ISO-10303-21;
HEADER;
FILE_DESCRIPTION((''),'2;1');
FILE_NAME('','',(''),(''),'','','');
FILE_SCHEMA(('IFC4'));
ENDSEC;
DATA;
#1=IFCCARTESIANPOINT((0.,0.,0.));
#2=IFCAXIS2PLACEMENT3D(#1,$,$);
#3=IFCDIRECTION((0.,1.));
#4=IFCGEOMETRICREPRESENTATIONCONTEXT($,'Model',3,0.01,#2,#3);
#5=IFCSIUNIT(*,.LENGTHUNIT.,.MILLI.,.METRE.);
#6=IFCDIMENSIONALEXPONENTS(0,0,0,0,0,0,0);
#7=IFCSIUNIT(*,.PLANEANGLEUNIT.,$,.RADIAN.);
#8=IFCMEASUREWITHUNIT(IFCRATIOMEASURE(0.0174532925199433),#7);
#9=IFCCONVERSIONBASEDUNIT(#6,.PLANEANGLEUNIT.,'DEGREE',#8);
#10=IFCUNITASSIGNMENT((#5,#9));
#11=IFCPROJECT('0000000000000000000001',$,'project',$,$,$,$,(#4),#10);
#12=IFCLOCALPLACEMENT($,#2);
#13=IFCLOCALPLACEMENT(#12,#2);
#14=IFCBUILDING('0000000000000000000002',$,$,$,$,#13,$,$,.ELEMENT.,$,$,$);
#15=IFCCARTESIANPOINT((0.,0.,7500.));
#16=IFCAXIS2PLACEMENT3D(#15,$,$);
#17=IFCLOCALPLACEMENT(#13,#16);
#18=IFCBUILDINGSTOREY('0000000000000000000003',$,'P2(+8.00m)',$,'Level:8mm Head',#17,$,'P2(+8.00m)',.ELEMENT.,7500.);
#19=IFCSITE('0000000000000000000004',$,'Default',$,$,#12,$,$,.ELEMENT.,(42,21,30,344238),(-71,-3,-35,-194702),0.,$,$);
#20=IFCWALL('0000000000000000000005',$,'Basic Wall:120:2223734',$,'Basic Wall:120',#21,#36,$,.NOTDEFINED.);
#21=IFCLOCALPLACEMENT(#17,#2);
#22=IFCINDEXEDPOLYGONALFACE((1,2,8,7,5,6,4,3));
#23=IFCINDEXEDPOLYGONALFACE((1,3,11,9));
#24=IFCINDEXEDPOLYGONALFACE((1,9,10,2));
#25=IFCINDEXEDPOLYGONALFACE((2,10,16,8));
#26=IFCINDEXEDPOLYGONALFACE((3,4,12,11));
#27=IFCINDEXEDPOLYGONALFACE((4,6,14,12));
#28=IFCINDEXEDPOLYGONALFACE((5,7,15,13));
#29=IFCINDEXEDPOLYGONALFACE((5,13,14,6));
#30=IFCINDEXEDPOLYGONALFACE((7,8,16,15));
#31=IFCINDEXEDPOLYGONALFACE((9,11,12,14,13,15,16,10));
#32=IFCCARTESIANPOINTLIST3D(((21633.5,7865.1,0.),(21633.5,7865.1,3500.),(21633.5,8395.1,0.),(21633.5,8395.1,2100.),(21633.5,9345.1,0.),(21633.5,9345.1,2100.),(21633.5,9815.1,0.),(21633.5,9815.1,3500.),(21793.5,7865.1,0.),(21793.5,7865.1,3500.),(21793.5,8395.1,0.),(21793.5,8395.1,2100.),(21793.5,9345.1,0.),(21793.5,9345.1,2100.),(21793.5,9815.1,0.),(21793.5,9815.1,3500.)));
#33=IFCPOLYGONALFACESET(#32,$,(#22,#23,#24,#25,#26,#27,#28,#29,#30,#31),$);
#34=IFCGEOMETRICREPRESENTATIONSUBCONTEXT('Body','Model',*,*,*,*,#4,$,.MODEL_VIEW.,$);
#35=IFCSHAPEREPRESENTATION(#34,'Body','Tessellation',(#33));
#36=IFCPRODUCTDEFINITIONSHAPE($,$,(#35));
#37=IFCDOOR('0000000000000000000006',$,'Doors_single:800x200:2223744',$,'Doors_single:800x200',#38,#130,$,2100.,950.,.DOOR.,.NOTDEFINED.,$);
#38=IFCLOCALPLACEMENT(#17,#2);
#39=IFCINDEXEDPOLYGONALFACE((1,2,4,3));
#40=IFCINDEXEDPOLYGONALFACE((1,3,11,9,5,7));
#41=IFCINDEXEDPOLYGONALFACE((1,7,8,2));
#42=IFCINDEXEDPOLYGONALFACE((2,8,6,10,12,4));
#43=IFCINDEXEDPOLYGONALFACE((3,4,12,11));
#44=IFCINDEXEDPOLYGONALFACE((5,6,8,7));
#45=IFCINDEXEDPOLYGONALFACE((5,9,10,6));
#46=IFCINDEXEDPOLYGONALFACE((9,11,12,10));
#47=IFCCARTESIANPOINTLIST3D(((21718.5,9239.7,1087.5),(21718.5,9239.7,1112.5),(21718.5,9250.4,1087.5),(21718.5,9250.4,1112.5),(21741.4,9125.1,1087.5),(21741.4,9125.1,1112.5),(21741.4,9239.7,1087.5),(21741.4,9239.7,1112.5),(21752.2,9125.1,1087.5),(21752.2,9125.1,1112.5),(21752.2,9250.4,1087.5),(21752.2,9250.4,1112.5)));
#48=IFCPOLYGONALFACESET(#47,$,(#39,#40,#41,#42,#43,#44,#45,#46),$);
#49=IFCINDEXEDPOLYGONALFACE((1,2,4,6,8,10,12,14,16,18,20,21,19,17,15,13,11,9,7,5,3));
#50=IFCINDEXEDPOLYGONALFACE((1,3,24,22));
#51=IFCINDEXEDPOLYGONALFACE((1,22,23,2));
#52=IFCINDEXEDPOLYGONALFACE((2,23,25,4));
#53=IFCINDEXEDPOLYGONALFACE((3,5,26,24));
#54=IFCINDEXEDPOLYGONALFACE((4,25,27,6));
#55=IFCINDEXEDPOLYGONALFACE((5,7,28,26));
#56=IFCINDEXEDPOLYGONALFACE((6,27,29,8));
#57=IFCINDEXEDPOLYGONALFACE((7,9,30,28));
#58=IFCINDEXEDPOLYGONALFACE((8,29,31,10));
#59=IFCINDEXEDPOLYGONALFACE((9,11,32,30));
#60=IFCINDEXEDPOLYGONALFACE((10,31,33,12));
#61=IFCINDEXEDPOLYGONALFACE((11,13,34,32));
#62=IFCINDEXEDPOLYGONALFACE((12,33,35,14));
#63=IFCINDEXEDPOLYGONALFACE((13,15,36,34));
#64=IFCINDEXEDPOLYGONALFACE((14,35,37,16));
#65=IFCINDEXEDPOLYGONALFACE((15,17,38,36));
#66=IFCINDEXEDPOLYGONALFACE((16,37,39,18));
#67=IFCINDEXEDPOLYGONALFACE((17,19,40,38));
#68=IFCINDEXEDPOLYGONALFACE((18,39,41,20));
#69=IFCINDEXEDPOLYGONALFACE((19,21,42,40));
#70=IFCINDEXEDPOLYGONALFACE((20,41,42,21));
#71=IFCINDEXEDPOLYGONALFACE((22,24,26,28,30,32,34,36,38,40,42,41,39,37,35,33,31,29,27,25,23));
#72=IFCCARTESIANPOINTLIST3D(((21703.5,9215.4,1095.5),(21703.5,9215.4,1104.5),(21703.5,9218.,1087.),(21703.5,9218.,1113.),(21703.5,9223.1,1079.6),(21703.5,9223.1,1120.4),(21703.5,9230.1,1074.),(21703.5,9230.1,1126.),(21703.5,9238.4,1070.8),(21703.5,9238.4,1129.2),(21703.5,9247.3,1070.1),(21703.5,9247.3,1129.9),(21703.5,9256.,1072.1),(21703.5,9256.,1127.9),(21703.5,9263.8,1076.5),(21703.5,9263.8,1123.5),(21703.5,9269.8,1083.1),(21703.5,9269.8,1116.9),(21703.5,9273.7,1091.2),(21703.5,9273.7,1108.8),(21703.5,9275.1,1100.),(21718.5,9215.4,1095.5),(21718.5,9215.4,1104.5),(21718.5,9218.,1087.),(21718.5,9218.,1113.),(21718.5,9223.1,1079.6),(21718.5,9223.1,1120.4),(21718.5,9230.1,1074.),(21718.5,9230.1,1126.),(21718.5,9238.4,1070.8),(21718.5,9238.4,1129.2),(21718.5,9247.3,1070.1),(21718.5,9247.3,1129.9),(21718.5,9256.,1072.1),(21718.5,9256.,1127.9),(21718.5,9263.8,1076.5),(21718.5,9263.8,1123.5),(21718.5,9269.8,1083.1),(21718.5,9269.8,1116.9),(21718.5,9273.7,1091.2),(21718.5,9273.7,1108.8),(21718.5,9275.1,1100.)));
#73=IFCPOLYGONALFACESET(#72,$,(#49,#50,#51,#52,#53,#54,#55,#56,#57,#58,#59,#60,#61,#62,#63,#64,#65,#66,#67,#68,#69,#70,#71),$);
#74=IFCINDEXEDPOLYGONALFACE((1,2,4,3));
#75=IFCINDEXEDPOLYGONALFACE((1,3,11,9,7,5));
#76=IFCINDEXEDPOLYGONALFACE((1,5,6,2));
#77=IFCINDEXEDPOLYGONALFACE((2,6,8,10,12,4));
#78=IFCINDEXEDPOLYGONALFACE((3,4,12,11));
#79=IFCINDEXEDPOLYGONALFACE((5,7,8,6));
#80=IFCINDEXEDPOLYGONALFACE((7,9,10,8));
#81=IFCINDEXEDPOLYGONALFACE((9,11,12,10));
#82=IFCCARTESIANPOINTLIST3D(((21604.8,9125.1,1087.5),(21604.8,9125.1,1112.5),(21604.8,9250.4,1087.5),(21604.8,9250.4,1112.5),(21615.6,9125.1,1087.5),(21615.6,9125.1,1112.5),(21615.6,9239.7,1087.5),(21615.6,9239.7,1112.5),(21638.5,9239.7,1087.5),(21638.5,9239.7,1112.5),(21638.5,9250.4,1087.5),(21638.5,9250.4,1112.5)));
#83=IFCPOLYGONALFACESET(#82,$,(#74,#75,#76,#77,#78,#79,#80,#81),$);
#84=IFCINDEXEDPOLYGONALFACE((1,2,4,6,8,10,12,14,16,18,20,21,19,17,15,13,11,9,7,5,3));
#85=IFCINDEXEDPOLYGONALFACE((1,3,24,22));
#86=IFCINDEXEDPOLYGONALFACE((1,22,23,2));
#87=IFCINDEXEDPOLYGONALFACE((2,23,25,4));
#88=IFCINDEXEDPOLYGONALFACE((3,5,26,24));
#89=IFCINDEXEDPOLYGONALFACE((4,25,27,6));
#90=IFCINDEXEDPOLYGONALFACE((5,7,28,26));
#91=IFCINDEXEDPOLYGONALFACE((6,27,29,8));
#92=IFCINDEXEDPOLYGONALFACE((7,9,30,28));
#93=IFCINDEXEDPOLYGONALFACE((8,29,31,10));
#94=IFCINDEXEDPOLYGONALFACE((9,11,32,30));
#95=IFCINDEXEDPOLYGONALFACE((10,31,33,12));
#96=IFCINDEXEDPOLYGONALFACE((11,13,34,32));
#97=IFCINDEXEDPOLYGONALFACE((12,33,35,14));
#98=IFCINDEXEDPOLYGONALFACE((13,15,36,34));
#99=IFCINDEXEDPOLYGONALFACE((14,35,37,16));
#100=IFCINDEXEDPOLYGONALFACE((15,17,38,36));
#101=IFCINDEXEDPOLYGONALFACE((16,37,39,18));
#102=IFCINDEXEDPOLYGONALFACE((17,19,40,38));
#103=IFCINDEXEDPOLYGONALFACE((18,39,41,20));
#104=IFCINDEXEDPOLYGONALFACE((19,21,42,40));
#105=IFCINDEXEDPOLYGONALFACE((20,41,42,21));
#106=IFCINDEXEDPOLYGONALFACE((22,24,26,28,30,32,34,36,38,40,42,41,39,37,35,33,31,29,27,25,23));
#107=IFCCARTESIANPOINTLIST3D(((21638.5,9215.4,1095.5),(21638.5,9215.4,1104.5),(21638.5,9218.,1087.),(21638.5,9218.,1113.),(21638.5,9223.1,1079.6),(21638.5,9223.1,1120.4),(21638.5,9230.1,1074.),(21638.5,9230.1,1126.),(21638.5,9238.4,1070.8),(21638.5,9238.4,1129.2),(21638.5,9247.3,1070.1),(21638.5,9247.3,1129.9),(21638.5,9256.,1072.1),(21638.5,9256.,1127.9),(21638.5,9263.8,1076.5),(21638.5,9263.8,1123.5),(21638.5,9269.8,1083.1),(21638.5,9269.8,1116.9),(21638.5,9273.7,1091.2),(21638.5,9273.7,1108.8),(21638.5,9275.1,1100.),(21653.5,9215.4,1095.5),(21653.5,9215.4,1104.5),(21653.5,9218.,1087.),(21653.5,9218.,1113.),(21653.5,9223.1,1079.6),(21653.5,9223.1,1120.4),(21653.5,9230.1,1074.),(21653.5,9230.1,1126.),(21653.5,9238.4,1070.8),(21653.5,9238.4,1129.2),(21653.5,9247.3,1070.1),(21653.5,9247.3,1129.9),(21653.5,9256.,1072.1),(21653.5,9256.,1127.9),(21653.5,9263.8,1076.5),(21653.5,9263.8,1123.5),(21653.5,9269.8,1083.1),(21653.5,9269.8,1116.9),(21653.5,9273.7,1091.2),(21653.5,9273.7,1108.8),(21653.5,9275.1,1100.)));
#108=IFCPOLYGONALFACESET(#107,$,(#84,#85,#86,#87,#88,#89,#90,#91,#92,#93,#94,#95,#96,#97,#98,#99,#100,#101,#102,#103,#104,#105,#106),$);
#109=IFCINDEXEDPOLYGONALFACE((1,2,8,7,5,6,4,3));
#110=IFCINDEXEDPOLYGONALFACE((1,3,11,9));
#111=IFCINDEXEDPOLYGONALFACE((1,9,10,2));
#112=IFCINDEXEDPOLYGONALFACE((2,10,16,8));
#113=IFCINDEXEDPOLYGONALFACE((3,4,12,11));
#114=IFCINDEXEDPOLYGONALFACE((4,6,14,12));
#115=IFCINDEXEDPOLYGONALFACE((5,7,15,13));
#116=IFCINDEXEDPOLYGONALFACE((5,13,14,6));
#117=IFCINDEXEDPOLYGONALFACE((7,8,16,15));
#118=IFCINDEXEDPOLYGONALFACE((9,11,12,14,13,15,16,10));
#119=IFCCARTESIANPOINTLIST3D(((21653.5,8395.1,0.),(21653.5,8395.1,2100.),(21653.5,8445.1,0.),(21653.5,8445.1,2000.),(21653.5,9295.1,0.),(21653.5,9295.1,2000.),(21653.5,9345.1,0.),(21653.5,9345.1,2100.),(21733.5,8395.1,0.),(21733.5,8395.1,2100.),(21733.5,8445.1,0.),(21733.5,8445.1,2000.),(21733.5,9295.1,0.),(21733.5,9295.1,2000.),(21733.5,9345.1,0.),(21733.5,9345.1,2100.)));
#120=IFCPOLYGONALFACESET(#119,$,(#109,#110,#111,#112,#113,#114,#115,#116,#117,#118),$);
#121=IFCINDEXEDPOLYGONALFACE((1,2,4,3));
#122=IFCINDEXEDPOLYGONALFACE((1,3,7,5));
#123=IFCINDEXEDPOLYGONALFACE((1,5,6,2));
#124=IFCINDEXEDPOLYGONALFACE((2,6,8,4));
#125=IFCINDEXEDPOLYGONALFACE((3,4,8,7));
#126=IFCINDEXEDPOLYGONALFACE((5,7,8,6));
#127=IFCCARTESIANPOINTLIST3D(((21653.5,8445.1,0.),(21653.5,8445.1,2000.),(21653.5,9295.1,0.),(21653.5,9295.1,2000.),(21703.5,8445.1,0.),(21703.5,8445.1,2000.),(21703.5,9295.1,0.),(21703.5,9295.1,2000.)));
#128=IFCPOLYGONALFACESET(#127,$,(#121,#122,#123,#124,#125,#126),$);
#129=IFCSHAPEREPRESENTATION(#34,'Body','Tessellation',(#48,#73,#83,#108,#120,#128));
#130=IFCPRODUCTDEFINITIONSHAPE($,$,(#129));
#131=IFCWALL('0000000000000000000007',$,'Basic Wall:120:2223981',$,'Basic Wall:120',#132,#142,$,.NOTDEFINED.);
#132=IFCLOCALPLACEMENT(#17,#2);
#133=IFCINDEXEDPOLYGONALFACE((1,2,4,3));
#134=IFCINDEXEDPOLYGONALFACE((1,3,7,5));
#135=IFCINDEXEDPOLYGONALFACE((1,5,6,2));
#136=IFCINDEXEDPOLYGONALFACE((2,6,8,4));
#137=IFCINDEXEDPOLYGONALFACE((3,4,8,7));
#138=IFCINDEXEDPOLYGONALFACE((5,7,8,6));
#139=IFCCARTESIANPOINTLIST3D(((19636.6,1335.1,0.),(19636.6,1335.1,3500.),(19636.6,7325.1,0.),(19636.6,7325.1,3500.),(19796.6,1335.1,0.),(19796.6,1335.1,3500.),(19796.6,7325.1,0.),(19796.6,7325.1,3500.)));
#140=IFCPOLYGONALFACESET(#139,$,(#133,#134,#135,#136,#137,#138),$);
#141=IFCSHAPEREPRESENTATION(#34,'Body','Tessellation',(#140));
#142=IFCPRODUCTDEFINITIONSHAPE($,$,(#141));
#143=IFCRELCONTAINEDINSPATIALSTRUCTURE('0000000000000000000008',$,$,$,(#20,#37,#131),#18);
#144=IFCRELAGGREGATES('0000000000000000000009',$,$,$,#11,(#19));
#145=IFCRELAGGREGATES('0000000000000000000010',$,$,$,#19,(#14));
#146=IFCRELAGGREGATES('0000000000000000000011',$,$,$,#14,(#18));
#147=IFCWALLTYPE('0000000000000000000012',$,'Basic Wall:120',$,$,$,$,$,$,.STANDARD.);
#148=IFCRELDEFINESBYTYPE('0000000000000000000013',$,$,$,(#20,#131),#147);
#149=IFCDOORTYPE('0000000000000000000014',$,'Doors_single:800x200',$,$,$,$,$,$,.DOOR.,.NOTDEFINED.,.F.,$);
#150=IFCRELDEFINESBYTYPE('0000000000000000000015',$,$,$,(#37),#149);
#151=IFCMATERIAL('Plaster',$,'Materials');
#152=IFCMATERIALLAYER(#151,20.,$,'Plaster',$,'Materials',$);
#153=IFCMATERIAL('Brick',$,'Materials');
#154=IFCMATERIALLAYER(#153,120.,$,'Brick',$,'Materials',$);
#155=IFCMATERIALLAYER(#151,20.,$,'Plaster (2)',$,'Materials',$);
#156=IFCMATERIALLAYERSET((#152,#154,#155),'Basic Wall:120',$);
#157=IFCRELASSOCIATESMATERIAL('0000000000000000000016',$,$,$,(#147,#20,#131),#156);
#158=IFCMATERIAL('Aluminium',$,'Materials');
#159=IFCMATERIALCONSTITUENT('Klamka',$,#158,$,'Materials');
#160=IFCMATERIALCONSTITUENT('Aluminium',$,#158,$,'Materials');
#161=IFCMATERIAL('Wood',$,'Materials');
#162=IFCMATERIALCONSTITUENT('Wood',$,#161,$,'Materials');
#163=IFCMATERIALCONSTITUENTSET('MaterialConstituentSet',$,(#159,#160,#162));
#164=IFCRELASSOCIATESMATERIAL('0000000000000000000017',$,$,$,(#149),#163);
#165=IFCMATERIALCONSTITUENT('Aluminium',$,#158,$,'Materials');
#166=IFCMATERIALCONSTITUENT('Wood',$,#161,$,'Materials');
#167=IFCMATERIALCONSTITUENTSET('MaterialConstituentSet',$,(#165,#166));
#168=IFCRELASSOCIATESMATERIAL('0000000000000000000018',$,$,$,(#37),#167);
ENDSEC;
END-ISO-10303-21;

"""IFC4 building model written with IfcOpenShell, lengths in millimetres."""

from ifc_helpers import new_model, entity, si_unit, converted_unit, direction, frame, frame_2d, origin, origin_2d_with_axis, place, context, subcontext, project, spatial, polyline, rectangle, circle, outline, extrude, source, transform, mapped, material, layer, layer_set, layer_usage, constituent, constituent_set, type_object, type_shapes, element, fill, save


model = new_model("IFC4")

# Units and contexts
model_context = context("Model", 3, precision=0.01, world=origin(), true_north=direction((0.0, 1.0)))
body_context = subcontext(model_context, "Body", "Model", "MODEL_VIEW")
ifc_project = project(units=[si_unit("LENGTHUNIT", "METRE", prefix="MILLI"), converted_unit("PLANEANGLEUNIT", "DEGREE", entity("IfcRatioMeasure", 0.0174532925199433), si_unit("PLANEANGLEUNIT", "RADIAN"), dimensions=[0, 0, 0, 0, 0, 0, 0])], contexts=[model_context])

# Site, building, storey
site_placement = place(None, origin())
site = spatial("IfcSite", under=ifc_project, at=site_placement, Name="Default", CompositionType="ELEMENT", RefLatitude=(42, 21, 30, 344238), RefLongitude=(-71, -3, -35, -194702), RefElevation=0.0)
building_placement = place(site_placement, origin())
building = spatial("IfcBuilding", under=site, at=building_placement, CompositionType="ELEMENT")
storey_placement = place(building_placement, frame((0.0, 0.0, 7500.0)))
storey = spatial("IfcBuildingStorey", under=building, at=storey_placement, Name="P2(+8.00m)", ObjectType="Level:8mm Head", LongName="P2(+8.00m)", CompositionType="ELEMENT", Elevation=7500.0)

# Shared definitions
ifc_material_1 = material(Name="Brick", Category="Materials")
ifc_material_2 = material(Name="Plaster", Category="Materials")

# Shared definitions
ifc_layer_1 = layer(ifc_material_2, 20.0, Name="Plaster", Category="Materials")
ifc_layer_2 = layer(ifc_material_1, 120.0, Name="Brick", Category="Materials")
ifc_layer_3 = layer(ifc_material_2, 20.0, Name="Plaster (2)", Category="Materials")
ifc_layer_set_1 = layer_set([ifc_layer_1, ifc_layer_2, ifc_layer_3], Name="Basic Wall:120")
wall_type_1 = type_object("IfcWallType", Name="Basic Wall:120", PredefinedType="STANDARD", material=ifc_layer_set_1)

# Wall, opening, door
ifc_material_3 = material(Name="Aluminium", Category="Materials")
ifc_material_4 = material(Name="Wood", Category="Materials")
ifc_layer_usage_1 = layer_usage(ifc_layer_set_1, "AXIS2", "NEGATIVE", 80.0)
wall_1_placement = place(storey_placement, frame((21713.5, 9815.1, 0.0), z_axis=(0.0, 0.0, 1.0), x_axis=(0.0, -1.0, 0.0)))
wall_1 = element("IfcWall", 1, at=wall_1_placement, inside=storey, type_object=wall_type_1, material=ifc_layer_usage_1, Name="Basic Wall:120:2223734", ObjectType="Basic Wall:120", PredefinedType="NOTDEFINED", context=body_context, shape_type="SweptSolid", body=[
    extrude(rectangle(XDim=1950.0, YDim=160.0, at=frame_2d((975.0, 0.0), x_axis=(-1.0, 0.0))), origin(), (0.0, 0.0, 1.0), 3500.0),
])
opening_1_placement = place(wall_1_placement, frame((1420.0, 80.0, 0.0)))
opening_1 = element("IfcOpeningElement", 2, at=opening_1_placement, cuts=wall_1, PredefinedType="OPENING", context=body_context, shape_type="SweptSolid", body=[
    extrude(rectangle(XDim=2100.0, YDim=950.0, at=frame_2d((1050.0, 475.0), x_axis=(1.0, 0.0))), frame((0.0, 0.0, 0.0), z_axis=(0.0, -1.0, 0.0), x_axis=(0.0, 0.0, 1.0)), (0.0, 0.0, 1.0), 160.0),
])
ifc_constituent_1 = constituent(ifc_material_3, Name="Aluminium", Category="Materials")
ifc_constituent_2 = constituent(ifc_material_4, Name="Wood", Category="Materials")
ifc_constituent_set_1 = constituent_set(constituents=[ifc_constituent_1, ifc_constituent_2], Name="MaterialConstituentSet")
ifc_constituent_3 = constituent(ifc_material_3, Name="Klamka", Category="Materials")
ifc_constituent_4 = constituent(ifc_material_3, Name="Aluminium", Category="Materials")
ifc_constituent_5 = constituent(ifc_material_4, Name="Wood", Category="Materials")
ifc_constituent_set_2 = constituent_set(constituents=[ifc_constituent_3, ifc_constituent_4, ifc_constituent_5], Name="MaterialConstituentSet")
door_type_1 = type_object("IfcDoorType", Name="Doors_single:800x200", OperationType="NOTDEFINED", ParameterTakesPrecedence=False, PredefinedType="DOOR", material=ifc_constituent_set_2)
shared_shape_1 = source(origin(), body_context, "Body", "SweptSolid", [
    extrude(outline(polyline([(-45.4, -18.9), (-34.6, -18.9), (-34.6, 4.0), (80.0, 4.0), (80.0, 14.8), (-45.4, 14.8), (-45.4, -18.9)])), frame((810.0, 56.1, 1087.5), z_axis=(0.0, 0.0, 1.0), x_axis=(-1.0, 0.0, 0.0)), (0.0, 0.0, 1.0), 25.0),
    extrude(circle(Radius=30.0, at=origin_2d_with_axis()), frame((850.0, 75.0, 1100.0), z_axis=(0.0, 1.0, 0.0), x_axis=(1.0, 0.0, 0.0)), (0.0, 0.0, 1.0), 15.0),
    extrude(outline(polyline([(-18.9, -45.4), (14.8, -45.4), (14.8, 80.0), (4.0, 80.0), (4.0, -34.6), (-18.9, -34.6), (-18.9, -45.4)])), frame((810.0, 173.9, 1087.5), z_axis=(0.0, 0.0, 1.0), x_axis=(0.0, 1.0, 0.0)), (0.0, 0.0, 1.0), 25.0),
    extrude(circle(Radius=30.0, at=origin_2d_with_axis()), frame((850.0, 140.0, 1100.0), z_axis=(0.0, 1.0, 0.0), x_axis=(1.0, 0.0, 0.0)), (0.0, 0.0, 1.0), 15.0),
    extrude(outline(polyline([(-475.0, -1025.0), (-425.0, -1025.0), (-425.0, 975.0), (425.0, 975.0), (425.0, -1025.0), (475.0, -1025.0), (475.0, 1075.0), (-475.0, 1075.0), (-475.0, -1025.0)])), frame((475.0, 60.0, 1025.0), z_axis=(0.0, 1.0, 0.0), x_axis=(-1.0, 0.0, 0.0)), (0.0, 0.0, 1.0), 80.0),
    extrude(rectangle(XDim=850.0, YDim=50.0, at=origin_2d_with_axis()), frame((475.0, 115.0, 0.0), z_axis=(0.0, 0.0, 1.0), x_axis=(-1.0, 0.0, 0.0)), (0.0, 0.0, 1.0), 2000.0),
])
type_shapes(door_type_1, [shared_shape_1])
door_1_placement = place(opening_1_placement, frame((0.0, 0.0, 0.0), z_axis=(0.0, 0.0, 1.0), x_axis=(-1.0, 0.0, 0.0)))
door_1 = element("IfcDoor", 3, at=door_1_placement, inside=storey, type_object=door_type_1, material=ifc_constituent_set_1, Name="Doors_single:800x200:2223744", ObjectType="Doors_single:800x200", OperationType="NOTDEFINED", OverallHeight=2100.0, OverallWidth=950.0, PredefinedType="DOOR", context=body_context, shape_type="MappedRepresentation", body=[
    mapped(shared_shape_1, transform((0.0, 0.0, 0.0), scale=1.0)),
])
fill(opening_1, door_1)

# Wall
ifc_layer_usage_2 = layer_usage(ifc_layer_set_1, "AXIS2", "POSITIVE", -80.0)
wall_2_placement = place(storey_placement, frame((19716.6, 7325.1, 0.0), z_axis=(0.0, 0.0, 1.0), x_axis=(0.0, -1.0, 0.0)))
element("IfcWall", 4, at=wall_2_placement, inside=storey, type_object=wall_type_1, material=ifc_layer_usage_2, Name="Basic Wall:120:2223981", ObjectType="Basic Wall:120", PredefinedType="NOTDEFINED", context=body_context, shape_type="SweptSolid", body=[
    extrude(rectangle(XDim=5990.0, YDim=160.0, at=frame_2d((2995.0, 0.0), x_axis=(-1.0, 0.0))), origin(), (0.0, 0.0, 1.0), 3500.0),
])

save(model, "model.ifc")
